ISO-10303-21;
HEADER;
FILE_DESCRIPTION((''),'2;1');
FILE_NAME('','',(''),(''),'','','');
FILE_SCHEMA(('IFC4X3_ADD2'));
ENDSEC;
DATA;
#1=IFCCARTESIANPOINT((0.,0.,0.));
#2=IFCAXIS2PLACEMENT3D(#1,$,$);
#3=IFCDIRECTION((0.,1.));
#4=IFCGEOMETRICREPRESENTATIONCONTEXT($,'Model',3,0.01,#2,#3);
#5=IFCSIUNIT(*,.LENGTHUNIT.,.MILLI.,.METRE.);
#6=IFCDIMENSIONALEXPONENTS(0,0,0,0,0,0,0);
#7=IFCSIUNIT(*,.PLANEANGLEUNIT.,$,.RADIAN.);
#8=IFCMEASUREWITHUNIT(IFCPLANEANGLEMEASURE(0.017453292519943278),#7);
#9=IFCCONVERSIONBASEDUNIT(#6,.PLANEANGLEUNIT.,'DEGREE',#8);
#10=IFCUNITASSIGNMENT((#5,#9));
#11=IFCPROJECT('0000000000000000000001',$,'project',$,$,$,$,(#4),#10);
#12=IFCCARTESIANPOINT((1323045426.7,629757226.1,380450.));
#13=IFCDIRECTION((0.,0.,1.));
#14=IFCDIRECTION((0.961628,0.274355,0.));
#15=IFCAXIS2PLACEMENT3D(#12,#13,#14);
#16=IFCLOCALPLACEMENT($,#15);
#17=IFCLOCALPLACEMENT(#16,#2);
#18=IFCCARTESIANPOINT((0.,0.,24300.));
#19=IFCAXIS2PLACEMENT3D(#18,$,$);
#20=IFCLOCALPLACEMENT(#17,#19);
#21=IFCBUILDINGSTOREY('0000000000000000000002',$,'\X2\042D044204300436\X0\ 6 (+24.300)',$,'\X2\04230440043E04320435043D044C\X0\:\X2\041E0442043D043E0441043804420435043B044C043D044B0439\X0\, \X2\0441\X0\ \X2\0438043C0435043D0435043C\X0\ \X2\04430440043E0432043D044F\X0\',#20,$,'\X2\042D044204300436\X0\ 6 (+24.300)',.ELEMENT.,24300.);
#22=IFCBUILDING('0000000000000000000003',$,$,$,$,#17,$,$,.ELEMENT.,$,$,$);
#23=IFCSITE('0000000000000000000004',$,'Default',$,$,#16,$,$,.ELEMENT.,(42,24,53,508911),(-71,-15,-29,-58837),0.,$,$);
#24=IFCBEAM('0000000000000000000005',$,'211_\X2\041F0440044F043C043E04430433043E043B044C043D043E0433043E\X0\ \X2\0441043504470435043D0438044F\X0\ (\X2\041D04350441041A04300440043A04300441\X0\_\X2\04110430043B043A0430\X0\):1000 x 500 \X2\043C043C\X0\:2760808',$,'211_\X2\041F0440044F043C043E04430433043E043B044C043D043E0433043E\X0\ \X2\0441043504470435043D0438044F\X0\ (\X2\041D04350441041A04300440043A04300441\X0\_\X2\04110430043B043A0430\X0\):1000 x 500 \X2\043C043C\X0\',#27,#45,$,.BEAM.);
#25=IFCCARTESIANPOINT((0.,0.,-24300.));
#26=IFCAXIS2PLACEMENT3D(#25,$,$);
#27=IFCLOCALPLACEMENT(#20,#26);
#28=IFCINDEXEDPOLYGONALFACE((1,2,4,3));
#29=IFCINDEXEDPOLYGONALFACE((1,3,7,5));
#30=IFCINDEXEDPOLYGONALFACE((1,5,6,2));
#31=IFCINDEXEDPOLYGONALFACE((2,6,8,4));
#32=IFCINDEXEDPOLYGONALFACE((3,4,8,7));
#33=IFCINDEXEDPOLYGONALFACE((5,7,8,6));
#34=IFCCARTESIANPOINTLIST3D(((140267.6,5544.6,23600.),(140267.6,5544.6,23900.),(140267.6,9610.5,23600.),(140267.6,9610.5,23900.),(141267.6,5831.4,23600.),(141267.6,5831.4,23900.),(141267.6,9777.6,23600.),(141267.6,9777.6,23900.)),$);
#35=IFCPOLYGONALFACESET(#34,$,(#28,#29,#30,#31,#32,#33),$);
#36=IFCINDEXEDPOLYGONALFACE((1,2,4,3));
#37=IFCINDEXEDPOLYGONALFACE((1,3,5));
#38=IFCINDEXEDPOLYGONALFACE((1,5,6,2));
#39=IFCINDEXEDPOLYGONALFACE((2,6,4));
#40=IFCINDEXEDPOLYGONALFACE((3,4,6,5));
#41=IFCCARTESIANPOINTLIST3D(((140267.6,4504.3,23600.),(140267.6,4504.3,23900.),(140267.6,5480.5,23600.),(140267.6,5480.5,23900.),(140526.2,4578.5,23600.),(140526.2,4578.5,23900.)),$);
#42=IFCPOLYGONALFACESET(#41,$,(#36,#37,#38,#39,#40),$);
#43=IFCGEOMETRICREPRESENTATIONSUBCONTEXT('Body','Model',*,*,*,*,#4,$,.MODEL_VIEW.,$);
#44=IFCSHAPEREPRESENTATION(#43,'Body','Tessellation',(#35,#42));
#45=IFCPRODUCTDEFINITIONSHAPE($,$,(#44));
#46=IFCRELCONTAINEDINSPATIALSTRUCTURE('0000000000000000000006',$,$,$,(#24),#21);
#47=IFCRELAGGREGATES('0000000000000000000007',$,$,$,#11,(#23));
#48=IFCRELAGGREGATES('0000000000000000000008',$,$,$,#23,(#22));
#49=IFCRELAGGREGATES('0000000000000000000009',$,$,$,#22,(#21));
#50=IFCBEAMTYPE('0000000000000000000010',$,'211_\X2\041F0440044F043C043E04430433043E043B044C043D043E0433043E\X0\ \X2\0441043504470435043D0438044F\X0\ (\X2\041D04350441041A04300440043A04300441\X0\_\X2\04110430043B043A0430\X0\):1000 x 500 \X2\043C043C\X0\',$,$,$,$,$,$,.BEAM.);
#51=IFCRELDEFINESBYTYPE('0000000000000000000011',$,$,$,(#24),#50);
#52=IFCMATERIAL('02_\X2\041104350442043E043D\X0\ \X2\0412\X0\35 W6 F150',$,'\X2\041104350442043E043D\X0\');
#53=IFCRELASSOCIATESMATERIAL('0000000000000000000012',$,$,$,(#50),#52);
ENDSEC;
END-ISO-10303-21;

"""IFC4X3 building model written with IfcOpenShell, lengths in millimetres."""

from ifc_helpers import new_model, entity, si_unit, converted_unit, direction, frame, frame_2d, origin, place, context, subcontext, project, spatial, polyline, segment, composite_curve, rectangle, outline, extrude, clip, halfspace, source, transform, mapped, material, material_profile, profile_set, type_object, type_shapes, element, save


model = new_model("IFC4X3")

# Units and contexts
model_context = context("Model", 3, precision=0.01, world=origin(), true_north=direction((0.0, 1.0)))
body_context = subcontext(model_context, "Body", "Model", "MODEL_VIEW")
ifc_project = project(units=[si_unit("LENGTHUNIT", "METRE", prefix="MILLI"), converted_unit("PLANEANGLEUNIT", "DEGREE", entity("IfcPlaneAngleMeasure", 0.017453292519943278), si_unit("PLANEANGLEUNIT", "RADIAN"), dimensions=[0, 0, 0, 0, 0, 0, 0])], contexts=[model_context])

# Site, building, storey
site_placement = place(None, frame((1323045426.7, 629757226.1, 380450.0), z_axis=(0.0, 0.0, 1.0), x_axis=(0.961628, 0.274355, 0.0)))
site = spatial("IfcSite", under=ifc_project, at=site_placement, Name="Default", CompositionType="ELEMENT", RefLatitude=(42, 24, 53, 508911), RefLongitude=(-71, -15, -29, -58837), RefElevation=0.0)
building_placement = place(site_placement, origin())
building = spatial("IfcBuilding", under=site, at=building_placement, CompositionType="ELEMENT")
storey_placement = place(building_placement, frame((0.0, 0.0, 24300.0)))
storey = spatial("IfcBuildingStorey", under=building, at=storey_placement, Name="Этаж 6 (+24.300)", ObjectType="Уровень:Относительный, с именем уровня", LongName="Этаж 6 (+24.300)", CompositionType="ELEMENT", Elevation=24300.0)

# Beam
ifc_material = material(Name="02_Бетон В35 W6 F150", Category="Бетон")
ifc_material_profile_1 = material_profile(ifc_material, outline(composite_curve([segment(polyline([(-500.0, 150.0, 0.0), (500.0, 150.0, 0.0)]), True, "CONTINUOUS"), segment(polyline([(500.0, 150.0, 0.0), (500.0, -150.0, 0.0)]), True, "CONTINUOUS"), segment(polyline([(500.0, -150.0, 0.0), (-500.0, -150.0, 0.0)]), True, "CONTINUOUS"), segment(polyline([(-500.0, -150.0, 0.0), (-500.0, 150.0, 0.0)]), True, "CONTINUOUS")], self_intersect=False), kind="CURVE"), Name="1000 x 500 мм")
ifc_profile_set_1 = profile_set([ifc_material_profile_1], Name="1000 x 500 мм")
beam_type_1 = type_object("IfcBeamType", Name="211_Прямоугольного сечения (НесКаркас_Балка):1000 x 500 мм", PredefinedType="BEAM", material=ifc_profile_set_1)
shared_shape_1 = source(origin(), body_context, "Body", "SweptSolid", [
    clip(clip(extrude(rectangle(XDim=300.0, YDim=1000.0, at=frame_2d((0.0, 0.0), x_axis=(0.0, 1.0))), frame((140767.6, 5544.6, 23750.0), z_axis=(0.0, 1.0, 0.0), x_axis=(-1.0, 0.0, 0.0)), (0.0, 0.0, 1.0), 4233.0), halfspace(frame((140147.0, 9590.3, 23900.0), z_axis=(-0.164867, 0.986316, 0.0), x_axis=(0.986316, 0.164867, 0.0)), False)), halfspace(frame((140250.6, 5539.7, 23900.0), z_axis=(0.275637, -0.961262, 0.0), x_axis=(0.961262, 0.275637, 0.0)), False)),
    clip(clip(extrude(rectangle(XDim=300.0, YDim=258.6, at=frame_2d((0.0, 0.0), x_axis=(0.0, 1.0))), frame((140396.9, 4504.3, 23750.0), z_axis=(0.0, 1.0, 0.0), x_axis=(-1.0, 0.0, 0.0)), (0.0, 0.0, 1.0), 976.1), halfspace(frame((141331.3, 4809.3, 23900.0), z_axis=(0.275637, -0.961262, 0.0), x_axis=(-0.961262, -0.275637, 0.0)), False)), halfspace(frame((140388.4, 5059.1, 23750.0), z_axis=(0.961262, 0.275637, 0.0), x_axis=(0.0, 0.0, 1.0)), False)),
])
type_shapes(beam_type_1, [shared_shape_1])
beam_1_placement = place(storey_placement, frame((0.0, 0.0, -24300.0)))
element("IfcBeam", 1, at=beam_1_placement, inside=storey, type_object=beam_type_1, Name="211_Прямоугольного сечения (НесКаркас_Балка):1000 x 500 мм:2760808", ObjectType="211_Прямоугольного сечения (НесКаркас_Балка):1000 x 500 мм", PredefinedType="BEAM", context=body_context, shape_type="MappedRepresentation", body=[
    mapped(shared_shape_1, transform((0.0, 0.0, 0.0), scale=1.0)),
])

save(model, "model.ifc")
